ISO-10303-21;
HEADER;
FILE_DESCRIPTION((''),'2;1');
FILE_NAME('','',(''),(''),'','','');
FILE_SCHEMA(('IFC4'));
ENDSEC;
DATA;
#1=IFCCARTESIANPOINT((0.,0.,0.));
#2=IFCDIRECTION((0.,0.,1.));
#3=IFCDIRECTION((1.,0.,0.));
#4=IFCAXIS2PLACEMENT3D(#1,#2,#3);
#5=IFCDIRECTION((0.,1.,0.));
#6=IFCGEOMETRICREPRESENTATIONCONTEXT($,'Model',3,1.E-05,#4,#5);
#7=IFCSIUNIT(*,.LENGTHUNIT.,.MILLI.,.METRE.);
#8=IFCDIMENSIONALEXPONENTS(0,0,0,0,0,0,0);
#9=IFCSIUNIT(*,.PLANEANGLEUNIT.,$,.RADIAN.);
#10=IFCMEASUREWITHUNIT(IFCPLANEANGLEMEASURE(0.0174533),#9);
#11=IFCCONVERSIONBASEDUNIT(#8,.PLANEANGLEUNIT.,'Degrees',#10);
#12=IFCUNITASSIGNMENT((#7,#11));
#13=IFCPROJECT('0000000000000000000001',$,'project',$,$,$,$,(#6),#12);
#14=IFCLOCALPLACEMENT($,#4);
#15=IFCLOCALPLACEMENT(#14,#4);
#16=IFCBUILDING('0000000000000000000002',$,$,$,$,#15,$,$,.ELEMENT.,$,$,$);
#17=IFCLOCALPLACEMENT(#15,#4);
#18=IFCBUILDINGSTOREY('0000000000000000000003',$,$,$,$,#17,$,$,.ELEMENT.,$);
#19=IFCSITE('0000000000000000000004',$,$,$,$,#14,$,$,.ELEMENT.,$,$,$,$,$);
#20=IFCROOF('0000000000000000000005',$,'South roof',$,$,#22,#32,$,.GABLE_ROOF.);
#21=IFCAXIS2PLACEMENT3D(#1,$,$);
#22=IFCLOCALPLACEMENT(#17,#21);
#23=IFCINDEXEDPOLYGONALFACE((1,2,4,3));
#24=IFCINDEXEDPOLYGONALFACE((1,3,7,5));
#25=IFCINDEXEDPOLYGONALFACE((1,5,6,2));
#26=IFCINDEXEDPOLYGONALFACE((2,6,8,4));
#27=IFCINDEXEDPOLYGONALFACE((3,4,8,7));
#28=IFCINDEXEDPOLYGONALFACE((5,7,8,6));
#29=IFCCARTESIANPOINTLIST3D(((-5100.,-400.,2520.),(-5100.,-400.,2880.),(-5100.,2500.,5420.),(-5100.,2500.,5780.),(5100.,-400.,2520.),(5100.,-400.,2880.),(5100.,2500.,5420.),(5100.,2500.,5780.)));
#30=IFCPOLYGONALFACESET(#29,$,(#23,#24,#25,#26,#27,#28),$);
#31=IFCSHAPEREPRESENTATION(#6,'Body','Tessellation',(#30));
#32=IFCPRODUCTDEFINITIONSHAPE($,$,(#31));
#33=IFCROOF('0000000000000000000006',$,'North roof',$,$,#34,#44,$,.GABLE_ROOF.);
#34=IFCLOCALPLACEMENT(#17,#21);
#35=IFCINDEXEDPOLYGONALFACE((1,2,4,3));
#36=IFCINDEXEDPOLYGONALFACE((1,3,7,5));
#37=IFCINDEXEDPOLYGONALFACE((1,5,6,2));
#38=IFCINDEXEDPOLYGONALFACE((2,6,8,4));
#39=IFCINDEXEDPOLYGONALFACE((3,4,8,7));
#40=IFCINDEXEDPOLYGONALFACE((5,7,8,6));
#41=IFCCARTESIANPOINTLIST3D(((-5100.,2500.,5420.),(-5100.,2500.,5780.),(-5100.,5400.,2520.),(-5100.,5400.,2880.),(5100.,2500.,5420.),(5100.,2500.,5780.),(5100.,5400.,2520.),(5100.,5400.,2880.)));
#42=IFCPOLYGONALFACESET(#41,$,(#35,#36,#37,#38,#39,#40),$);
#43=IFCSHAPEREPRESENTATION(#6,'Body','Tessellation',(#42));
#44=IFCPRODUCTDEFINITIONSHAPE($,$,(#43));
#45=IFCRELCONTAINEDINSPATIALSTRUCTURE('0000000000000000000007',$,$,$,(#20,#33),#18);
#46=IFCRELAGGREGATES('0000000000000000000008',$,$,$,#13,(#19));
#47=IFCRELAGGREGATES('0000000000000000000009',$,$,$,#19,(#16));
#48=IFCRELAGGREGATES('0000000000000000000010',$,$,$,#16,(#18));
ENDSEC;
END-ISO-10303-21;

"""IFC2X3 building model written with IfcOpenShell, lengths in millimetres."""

from ifc_helpers import new_model, entity, si_unit, converted_unit, direction, frame, origin_with_axes, place, context, project, spatial, polyline, outline, extrude, element, save


model = new_model("IFC2X3")

# Units and contexts
model_context = context("Model", 3, precision=1e-05, world=origin_with_axes(), true_north=direction((0.0, 1.0, 0.0)))
ifc_project = project(units=[si_unit("LENGTHUNIT", "METRE", prefix="MILLI"), converted_unit("PLANEANGLEUNIT", "Degrees", entity("IfcPlaneAngleMeasure", 0.0174533), si_unit("PLANEANGLEUNIT", "RADIAN"), dimensions=[0, 0, 0, 0, 0, 0, 0])], contexts=[model_context])

# Site, building, storey
site_placement = place(None, origin_with_axes())
site = spatial("IfcSite", under=ifc_project, at=site_placement, CompositionType="ELEMENT")
building_placement = place(site_placement, origin_with_axes())
building = spatial("IfcBuilding", under=site, at=building_placement, CompositionType="ELEMENT")
storey_placement = place(building_placement, origin_with_axes())
storey = spatial("IfcBuildingStorey", under=building, at=storey_placement, CompositionType="ELEMENT")

# Roofs
for number, where, z_axis, x_axis, name in (
    (1, (0.0, -400.0, 2700.0), (0.0, 0.0, 1.0), (1.0, 0.0, 0.0), "South roof"),
    (2, (0.0, 5400.0, 2700.0), (0.0, 0.0, 1.0), (-1.0, 0.0, 0.0), "North roof"),
):
    element("IfcRoof", number, at=place(storey_placement, frame(where, z_axis=z_axis, x_axis=x_axis)), inside=storey, Name=name, ShapeType="GABLE_ROOF", context=model_context, shape_type="SweptSolid", body=[
        extrude(outline(polyline([(-5100.0, -180.0), (5100.0, -180.0), (5100.0, 180.0), (-5100.0, 180.0), (-5100.0, -180.0), (-5100.0, -180.0)])), frame((0.0, 0.0, 0.0), z_axis=(0.0, 1.0, 0.0), x_axis=(1.0, 0.0, 0.0)), (0.0, -0.707107, 0.707107), 4101.2),
    ])

save(model, "model.ifc")
